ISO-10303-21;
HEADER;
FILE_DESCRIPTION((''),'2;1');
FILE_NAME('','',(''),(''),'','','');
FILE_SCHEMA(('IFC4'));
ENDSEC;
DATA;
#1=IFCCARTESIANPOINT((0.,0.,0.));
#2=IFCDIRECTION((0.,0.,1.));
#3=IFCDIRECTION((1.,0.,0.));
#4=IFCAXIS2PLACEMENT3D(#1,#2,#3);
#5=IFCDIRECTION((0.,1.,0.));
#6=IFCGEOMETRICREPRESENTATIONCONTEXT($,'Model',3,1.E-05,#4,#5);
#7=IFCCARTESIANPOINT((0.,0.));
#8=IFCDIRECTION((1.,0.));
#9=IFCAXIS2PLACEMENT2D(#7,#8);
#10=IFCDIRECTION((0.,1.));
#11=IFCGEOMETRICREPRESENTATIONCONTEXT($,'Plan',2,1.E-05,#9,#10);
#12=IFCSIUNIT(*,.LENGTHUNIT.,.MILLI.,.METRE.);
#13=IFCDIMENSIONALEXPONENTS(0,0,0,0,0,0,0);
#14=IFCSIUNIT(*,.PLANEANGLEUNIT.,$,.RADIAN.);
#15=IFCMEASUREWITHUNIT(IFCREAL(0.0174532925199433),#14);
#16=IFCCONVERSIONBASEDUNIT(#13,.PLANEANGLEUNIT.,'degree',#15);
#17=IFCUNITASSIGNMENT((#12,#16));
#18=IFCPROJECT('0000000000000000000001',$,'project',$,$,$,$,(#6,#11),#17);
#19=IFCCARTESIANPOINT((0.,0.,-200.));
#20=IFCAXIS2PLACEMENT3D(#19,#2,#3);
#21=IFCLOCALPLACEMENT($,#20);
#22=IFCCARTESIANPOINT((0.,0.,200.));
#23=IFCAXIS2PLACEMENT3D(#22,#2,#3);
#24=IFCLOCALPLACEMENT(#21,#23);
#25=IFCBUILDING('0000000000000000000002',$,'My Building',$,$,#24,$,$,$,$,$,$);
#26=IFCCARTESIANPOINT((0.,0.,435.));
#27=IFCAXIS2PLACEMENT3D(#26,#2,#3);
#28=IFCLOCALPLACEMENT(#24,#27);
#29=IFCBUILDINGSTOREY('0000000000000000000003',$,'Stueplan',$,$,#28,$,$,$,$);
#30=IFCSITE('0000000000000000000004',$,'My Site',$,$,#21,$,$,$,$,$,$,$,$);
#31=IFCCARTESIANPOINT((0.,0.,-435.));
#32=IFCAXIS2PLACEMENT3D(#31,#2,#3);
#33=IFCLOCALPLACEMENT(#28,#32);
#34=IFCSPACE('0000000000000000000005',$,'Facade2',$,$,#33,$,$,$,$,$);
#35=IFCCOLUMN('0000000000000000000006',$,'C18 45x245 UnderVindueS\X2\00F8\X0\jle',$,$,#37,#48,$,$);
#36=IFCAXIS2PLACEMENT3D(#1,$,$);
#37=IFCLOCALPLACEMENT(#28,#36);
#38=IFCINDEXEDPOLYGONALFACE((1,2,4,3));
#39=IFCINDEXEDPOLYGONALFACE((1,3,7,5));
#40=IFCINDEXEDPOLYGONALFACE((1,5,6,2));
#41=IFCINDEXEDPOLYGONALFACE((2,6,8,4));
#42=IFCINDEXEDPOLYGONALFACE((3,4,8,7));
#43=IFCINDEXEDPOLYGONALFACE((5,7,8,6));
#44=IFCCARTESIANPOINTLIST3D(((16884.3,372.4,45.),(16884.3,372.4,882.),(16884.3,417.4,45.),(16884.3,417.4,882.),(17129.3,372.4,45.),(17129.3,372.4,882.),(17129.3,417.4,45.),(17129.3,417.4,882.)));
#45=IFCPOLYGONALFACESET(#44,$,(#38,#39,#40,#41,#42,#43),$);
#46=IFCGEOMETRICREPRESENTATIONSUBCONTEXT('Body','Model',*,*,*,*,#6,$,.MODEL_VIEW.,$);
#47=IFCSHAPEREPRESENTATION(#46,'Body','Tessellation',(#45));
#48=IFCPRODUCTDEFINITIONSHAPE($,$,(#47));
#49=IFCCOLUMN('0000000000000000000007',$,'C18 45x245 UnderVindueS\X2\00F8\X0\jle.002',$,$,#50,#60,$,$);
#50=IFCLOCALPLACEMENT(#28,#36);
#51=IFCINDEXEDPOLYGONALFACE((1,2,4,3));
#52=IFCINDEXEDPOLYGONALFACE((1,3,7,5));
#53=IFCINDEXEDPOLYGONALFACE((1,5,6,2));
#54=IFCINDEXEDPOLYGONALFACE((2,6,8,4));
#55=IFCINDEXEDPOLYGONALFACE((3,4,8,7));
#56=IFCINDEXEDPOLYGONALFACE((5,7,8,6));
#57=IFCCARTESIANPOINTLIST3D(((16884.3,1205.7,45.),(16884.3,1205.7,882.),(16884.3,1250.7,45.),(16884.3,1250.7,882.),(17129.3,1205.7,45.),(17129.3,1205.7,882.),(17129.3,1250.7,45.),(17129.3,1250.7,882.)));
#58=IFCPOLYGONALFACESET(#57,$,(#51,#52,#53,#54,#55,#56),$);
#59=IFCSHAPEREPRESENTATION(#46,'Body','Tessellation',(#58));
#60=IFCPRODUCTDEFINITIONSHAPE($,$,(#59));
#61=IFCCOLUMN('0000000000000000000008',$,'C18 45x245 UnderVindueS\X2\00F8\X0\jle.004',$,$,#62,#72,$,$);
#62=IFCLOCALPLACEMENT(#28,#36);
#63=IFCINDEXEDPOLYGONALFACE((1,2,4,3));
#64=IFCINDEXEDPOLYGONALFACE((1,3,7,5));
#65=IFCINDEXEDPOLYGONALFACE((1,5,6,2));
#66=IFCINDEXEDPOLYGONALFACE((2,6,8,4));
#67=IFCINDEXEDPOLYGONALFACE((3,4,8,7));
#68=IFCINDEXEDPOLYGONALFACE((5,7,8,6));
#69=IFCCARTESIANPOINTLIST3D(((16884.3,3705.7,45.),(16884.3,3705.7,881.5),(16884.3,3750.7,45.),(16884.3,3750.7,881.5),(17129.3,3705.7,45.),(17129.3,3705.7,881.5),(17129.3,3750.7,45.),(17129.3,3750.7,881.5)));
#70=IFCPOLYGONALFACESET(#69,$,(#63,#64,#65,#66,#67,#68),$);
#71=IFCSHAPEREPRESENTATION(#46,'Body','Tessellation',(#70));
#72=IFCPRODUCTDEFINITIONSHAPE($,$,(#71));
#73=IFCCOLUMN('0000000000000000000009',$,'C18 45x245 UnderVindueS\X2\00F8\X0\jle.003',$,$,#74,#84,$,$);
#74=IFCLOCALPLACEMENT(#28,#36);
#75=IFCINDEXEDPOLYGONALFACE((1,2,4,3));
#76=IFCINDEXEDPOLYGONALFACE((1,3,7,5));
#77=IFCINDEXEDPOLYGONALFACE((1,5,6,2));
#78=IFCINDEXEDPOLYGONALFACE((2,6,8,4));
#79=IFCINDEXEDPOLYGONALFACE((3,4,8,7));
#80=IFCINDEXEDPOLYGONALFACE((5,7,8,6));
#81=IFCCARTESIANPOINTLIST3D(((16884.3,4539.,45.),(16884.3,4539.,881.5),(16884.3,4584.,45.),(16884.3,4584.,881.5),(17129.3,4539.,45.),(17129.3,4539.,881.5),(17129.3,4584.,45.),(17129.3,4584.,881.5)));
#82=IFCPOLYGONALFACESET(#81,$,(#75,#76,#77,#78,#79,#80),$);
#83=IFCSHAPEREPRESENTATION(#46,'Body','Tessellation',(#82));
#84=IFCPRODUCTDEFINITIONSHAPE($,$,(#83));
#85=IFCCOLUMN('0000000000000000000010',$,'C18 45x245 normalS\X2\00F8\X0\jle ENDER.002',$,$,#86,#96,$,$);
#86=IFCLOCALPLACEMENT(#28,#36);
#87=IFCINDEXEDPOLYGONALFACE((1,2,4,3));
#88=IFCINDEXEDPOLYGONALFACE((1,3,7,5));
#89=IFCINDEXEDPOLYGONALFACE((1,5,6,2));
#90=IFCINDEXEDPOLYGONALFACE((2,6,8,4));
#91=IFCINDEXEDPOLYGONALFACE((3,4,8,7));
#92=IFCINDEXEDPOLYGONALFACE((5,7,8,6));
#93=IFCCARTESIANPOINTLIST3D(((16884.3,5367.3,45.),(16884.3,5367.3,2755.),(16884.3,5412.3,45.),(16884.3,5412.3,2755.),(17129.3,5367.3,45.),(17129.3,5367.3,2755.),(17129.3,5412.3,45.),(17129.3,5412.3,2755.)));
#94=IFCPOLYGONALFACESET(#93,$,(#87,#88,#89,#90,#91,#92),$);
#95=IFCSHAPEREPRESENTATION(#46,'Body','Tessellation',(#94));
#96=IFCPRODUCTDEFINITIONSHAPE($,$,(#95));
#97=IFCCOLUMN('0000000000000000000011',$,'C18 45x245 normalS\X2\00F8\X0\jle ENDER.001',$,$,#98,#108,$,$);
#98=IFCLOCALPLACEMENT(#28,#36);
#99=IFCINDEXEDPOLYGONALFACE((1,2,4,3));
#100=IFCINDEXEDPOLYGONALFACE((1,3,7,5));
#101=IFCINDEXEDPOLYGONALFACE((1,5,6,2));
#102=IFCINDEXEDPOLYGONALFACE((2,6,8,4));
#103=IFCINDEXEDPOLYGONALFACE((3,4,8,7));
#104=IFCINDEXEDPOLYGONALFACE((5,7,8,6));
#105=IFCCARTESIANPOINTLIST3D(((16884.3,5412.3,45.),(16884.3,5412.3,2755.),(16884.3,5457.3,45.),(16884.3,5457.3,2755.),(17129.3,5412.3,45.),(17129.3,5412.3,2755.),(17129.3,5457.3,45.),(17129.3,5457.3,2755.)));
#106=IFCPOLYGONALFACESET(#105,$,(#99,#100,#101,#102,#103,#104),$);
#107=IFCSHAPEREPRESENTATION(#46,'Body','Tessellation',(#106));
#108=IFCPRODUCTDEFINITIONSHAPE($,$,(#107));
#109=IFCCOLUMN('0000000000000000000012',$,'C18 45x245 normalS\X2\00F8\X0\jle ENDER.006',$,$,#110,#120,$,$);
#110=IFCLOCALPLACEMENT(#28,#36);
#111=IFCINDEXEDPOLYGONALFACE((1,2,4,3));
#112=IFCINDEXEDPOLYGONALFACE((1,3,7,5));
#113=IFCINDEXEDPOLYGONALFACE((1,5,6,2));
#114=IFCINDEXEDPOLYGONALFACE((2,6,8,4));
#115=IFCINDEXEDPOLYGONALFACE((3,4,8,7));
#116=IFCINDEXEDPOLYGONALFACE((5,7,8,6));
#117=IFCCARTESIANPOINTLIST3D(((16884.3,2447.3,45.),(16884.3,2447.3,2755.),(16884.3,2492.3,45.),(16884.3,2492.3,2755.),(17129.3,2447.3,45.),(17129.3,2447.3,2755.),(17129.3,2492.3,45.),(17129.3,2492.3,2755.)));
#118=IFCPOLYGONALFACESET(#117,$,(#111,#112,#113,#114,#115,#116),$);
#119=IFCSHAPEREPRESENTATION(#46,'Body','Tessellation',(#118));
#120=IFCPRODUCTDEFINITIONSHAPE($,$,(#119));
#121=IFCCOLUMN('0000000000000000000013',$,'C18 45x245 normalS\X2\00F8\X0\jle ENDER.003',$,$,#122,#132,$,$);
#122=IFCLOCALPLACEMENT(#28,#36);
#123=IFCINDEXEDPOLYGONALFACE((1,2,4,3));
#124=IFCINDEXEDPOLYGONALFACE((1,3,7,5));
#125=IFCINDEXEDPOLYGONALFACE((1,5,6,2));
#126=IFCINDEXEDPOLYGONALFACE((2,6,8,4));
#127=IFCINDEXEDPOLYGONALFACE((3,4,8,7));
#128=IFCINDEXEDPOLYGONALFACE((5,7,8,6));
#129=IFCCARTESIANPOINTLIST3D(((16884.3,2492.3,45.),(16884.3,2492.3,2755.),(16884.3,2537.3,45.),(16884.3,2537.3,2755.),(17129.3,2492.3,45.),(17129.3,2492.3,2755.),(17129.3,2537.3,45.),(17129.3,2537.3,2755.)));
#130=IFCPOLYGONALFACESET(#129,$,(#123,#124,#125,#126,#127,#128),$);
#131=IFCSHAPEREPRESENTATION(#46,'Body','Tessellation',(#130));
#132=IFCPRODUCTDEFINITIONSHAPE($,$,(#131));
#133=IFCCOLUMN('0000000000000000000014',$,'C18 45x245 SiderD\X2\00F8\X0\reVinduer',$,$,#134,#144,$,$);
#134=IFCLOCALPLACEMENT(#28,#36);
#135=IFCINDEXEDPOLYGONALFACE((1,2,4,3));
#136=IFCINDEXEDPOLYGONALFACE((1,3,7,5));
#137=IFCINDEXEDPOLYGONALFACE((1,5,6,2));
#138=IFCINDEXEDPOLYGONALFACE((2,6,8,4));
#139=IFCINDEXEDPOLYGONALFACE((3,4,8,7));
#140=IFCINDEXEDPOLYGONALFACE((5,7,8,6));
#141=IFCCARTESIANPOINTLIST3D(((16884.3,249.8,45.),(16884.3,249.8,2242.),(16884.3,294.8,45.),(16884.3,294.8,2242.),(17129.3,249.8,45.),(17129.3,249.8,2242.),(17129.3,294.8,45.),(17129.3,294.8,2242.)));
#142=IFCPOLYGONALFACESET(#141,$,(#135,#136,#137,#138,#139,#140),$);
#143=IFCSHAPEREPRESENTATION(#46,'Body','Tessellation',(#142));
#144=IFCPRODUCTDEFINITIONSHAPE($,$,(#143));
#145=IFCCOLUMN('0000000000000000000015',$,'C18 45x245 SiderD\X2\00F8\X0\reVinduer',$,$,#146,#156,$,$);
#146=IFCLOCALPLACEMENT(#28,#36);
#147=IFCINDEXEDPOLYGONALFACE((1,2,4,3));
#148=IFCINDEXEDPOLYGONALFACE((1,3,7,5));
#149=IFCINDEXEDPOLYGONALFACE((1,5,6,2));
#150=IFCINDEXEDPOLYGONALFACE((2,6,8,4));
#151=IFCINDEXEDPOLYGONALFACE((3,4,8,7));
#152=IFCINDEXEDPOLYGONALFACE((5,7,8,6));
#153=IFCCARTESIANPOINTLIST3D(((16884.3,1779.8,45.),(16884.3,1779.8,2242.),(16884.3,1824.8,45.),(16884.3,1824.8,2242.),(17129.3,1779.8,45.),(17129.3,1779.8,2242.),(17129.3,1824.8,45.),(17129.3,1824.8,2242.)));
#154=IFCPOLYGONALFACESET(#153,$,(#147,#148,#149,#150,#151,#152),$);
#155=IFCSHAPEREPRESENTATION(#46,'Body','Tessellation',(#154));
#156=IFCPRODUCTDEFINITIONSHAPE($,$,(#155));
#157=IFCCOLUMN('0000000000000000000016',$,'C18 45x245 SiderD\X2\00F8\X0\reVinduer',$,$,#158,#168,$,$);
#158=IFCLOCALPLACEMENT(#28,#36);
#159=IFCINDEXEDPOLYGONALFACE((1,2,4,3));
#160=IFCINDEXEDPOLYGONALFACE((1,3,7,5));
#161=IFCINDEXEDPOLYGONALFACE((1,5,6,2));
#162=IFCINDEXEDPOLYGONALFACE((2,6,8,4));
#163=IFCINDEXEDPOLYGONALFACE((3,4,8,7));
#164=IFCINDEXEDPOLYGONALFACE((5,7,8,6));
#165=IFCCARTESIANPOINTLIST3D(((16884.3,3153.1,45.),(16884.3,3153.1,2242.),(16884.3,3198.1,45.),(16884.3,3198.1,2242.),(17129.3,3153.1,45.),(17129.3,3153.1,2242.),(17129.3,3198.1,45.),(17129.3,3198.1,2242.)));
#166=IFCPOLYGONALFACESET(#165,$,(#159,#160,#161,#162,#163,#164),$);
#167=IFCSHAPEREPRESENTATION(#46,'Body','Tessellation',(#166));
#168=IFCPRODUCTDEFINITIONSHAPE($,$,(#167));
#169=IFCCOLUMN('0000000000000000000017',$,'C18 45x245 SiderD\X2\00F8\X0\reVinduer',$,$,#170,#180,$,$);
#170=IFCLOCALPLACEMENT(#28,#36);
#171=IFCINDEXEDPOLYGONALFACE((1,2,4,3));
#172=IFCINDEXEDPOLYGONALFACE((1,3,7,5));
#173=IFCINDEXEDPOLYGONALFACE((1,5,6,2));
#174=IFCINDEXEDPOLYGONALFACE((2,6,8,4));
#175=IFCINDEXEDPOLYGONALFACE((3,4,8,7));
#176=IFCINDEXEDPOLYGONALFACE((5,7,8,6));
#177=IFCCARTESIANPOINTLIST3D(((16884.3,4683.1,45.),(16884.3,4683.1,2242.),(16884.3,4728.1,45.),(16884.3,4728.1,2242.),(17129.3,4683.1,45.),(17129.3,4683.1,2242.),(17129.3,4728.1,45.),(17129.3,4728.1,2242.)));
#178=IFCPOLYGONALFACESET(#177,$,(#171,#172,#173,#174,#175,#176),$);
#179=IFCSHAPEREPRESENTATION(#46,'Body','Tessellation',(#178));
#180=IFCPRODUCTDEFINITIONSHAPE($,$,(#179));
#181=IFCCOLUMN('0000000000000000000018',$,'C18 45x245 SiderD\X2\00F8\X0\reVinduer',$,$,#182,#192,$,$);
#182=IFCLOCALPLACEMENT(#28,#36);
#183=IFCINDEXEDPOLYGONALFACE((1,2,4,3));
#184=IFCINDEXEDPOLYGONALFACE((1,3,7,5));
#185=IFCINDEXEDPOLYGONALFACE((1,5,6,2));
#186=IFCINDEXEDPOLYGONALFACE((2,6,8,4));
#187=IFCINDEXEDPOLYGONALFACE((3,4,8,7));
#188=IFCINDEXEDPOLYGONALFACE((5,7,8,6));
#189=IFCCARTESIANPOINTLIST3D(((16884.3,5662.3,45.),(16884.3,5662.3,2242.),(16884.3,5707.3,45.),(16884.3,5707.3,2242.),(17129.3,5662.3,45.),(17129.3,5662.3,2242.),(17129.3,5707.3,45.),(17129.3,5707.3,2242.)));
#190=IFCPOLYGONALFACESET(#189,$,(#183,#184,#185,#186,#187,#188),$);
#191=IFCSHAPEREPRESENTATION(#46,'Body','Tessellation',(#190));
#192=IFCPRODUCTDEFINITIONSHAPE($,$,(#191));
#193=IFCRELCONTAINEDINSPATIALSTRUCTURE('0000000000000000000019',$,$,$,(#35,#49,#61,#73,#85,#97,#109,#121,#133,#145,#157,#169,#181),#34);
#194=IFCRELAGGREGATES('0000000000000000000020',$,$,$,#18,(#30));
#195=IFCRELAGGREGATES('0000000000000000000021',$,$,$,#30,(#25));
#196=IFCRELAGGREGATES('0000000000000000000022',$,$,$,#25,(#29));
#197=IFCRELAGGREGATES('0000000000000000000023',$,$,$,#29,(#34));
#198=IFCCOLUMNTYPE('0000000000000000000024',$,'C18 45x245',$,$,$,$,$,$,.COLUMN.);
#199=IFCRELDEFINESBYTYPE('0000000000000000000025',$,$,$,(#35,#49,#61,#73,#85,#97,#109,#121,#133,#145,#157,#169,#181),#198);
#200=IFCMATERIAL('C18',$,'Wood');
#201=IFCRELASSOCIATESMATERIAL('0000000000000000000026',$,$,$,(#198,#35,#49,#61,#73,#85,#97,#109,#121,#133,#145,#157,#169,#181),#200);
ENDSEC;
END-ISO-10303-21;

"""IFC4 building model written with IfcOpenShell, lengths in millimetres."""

from ifc_helpers import new_model, entity, si_unit, converted_unit, direction, frame, origin_with_axes, origin_2d_with_axis, place, context, subcontext, project, spatial, rectangle, extrude, material, material_profile, profile_set, profile_usage, type_object, element, save


model = new_model("IFC4")

# Units and contexts
model_context = context("Model", 3, precision=1e-05, world=origin_with_axes(), true_north=direction((0.0, 1.0, 0.0)))
plan_context = context("Plan", 2, precision=1e-05, world=origin_2d_with_axis(), true_north=direction((0.0, 1.0)))
body_context_1 = subcontext(model_context, "Body", "Model", "MODEL_VIEW")
ifc_project = project(units=[si_unit("LENGTHUNIT", "METRE", prefix="MILLI"), converted_unit("PLANEANGLEUNIT", "degree", entity("IfcReal", 0.0174532925199433), si_unit("PLANEANGLEUNIT", "RADIAN"), dimensions=[0, 0, 0, 0, 0, 0, 0])], contexts=[model_context, plan_context])

# Site, building, storey, space
site_placement = place(None, frame((0.0, 0.0, -200.0), z_axis=(0.0, 0.0, 1.0), x_axis=(1.0, 0.0, 0.0)))
site = spatial("IfcSite", under=ifc_project, at=site_placement, Name="My Site")
building_placement = place(site_placement, frame((0.0, 0.0, 200.0), z_axis=(0.0, 0.0, 1.0), x_axis=(1.0, 0.0, 0.0)))
building = spatial("IfcBuilding", under=site, at=building_placement, Name="My Building")
storey_placement = place(building_placement, frame((0.0, 0.0, 435.0), z_axis=(0.0, 0.0, 1.0), x_axis=(1.0, 0.0, 0.0)))
storey = spatial("IfcBuildingStorey", under=building, at=storey_placement, Name="Stueplan")
space_1_placement = place(storey_placement, frame((0.0, 0.0, -435.0), z_axis=(0.0, 0.0, 1.0), x_axis=(1.0, 0.0, 0.0)))
space_1 = spatial("IfcSpace", under=storey, at=space_1_placement, Name="Facade2")

# Columns
ifc_material = material(Name="C18", Category="Wood")
ifc_material_profile_1 = material_profile(ifc_material, rectangle(XDim=45.0, YDim=245.0))
ifc_profile_set_1 = profile_set([ifc_material_profile_1], Name="woodStructural")
ifc_profile_usage_1 = profile_usage(ifc_profile_set_1, cardinal=9)
column_type = type_object("IfcColumnType", Name="C18 45x245", PredefinedType="COLUMN", material=ifc_profile_set_1)
column_1_placement = place(space_1_placement, frame((17129.3, 417.4, 480.0), z_axis=(0.0, 0.0, 1.0), x_axis=(0.0, -1.0, 0.0)))
element("IfcColumn", 1, at=column_1_placement, inside=space_1, type_object=column_type, material=ifc_profile_usage_1, Name="C18 45x245 UnderVindueSøjle", context=body_context_1, shape_type="SweptSolid", body=[
    extrude(rectangle(XDim=45.0, YDim=245.0), frame((22.5, -122.5, 0.0), z_axis=(0.0, 0.0, 1.0), x_axis=(1.0, 0.0, 0.0)), (0.0, 0.0, 1.0), 837.0),
])
ifc_profile_usage_2 = profile_usage(ifc_profile_set_1, cardinal=9)
column_2_placement = place(space_1_placement, frame((17129.3, 1250.7, 480.0), z_axis=(0.0, 0.0, 1.0), x_axis=(0.0, -1.0, 0.0)))
element("IfcColumn", 2, at=column_2_placement, inside=space_1, type_object=column_type, material=ifc_profile_usage_2, Name="C18 45x245 UnderVindueSøjle.002", context=body_context_1, shape_type="SweptSolid", body=[
    extrude(rectangle(XDim=45.0, YDim=245.0), frame((22.5, -122.5, 0.0), z_axis=(0.0, 0.0, 1.0), x_axis=(1.0, 0.0, 0.0)), (0.0, 0.0, 1.0), 837.0),
])
ifc_profile_usage_3 = profile_usage(ifc_profile_set_1, cardinal=9)
column_3_placement = place(space_1_placement, frame((17129.3, 3750.7, 480.0), z_axis=(0.0, 0.0, 1.0), x_axis=(0.0, -1.0, 0.0)))
element("IfcColumn", 3, at=column_3_placement, inside=space_1, type_object=column_type, material=ifc_profile_usage_3, Name="C18 45x245 UnderVindueSøjle.004", context=body_context_1, shape_type="SweptSolid", body=[
    extrude(rectangle(XDim=45.0, YDim=245.0), frame((22.5, -122.5, 0.0), z_axis=(0.0, 0.0, 1.0), x_axis=(1.0, 0.0, 0.0)), (0.0, 0.0, 1.0), 836.5),
])
ifc_profile_usage_4 = profile_usage(ifc_profile_set_1, cardinal=9)
column_4_placement = place(space_1_placement, frame((17129.3, 4584.0, 480.0), z_axis=(0.0, 0.0, 1.0), x_axis=(0.0, -1.0, 0.0)))
element("IfcColumn", 4, at=column_4_placement, inside=space_1, type_object=column_type, material=ifc_profile_usage_4, Name="C18 45x245 UnderVindueSøjle.003", context=body_context_1, shape_type="SweptSolid", body=[
    extrude(rectangle(XDim=45.0, YDim=245.0), frame((22.5, -122.5, 0.0), z_axis=(0.0, 0.0, 1.0), x_axis=(1.0, 0.0, 0.0)), (0.0, 0.0, 1.0), 836.5),
])
ifc_profile_usage_5 = profile_usage(ifc_profile_set_1, cardinal=9)
column_5_placement = place(space_1_placement, frame((17129.3, 5412.3, 480.0), z_axis=(0.0, 0.0, 1.0), x_axis=(0.0, -1.0, 0.0)))
element("IfcColumn", 5, at=column_5_placement, inside=space_1, type_object=column_type, material=ifc_profile_usage_5, Name="C18 45x245 normalSøjle ENDER.002", context=body_context_1, shape_type="SweptSolid", body=[
    extrude(rectangle(XDim=45.0, YDim=245.0), frame((22.5, -122.5, 0.0), z_axis=(0.0, 0.0, 1.0), x_axis=(1.0, 0.0, 0.0)), (0.0, 0.0, 1.0), 2710.0),
])
ifc_profile_usage_6 = profile_usage(ifc_profile_set_1, cardinal=9)
column_6_placement = place(space_1_placement, frame((17129.3, 5457.3, 480.0), z_axis=(0.0, 0.0, 1.0), x_axis=(0.0, -1.0, 0.0)))
element("IfcColumn", 6, at=column_6_placement, inside=space_1, type_object=column_type, material=ifc_profile_usage_6, Name="C18 45x245 normalSøjle ENDER.001", context=body_context_1, shape_type="SweptSolid", body=[
    extrude(rectangle(XDim=45.0, YDim=245.0), frame((22.5, -122.5, 0.0), z_axis=(0.0, 0.0, 1.0), x_axis=(1.0, 0.0, 0.0)), (0.0, 0.0, 1.0), 2710.0),
])
ifc_profile_usage_7 = profile_usage(ifc_profile_set_1, cardinal=9)
column_7_placement = place(space_1_placement, frame((17129.3, 2492.3, 480.0), z_axis=(0.0, 0.0, 1.0), x_axis=(0.0, -1.0, 0.0)))
element("IfcColumn", 7, at=column_7_placement, inside=space_1, type_object=column_type, material=ifc_profile_usage_7, Name="C18 45x245 normalSøjle ENDER.006", context=body_context_1, shape_type="SweptSolid", body=[
    extrude(rectangle(XDim=45.0, YDim=245.0), frame((22.5, -122.5, 0.0), z_axis=(0.0, 0.0, 1.0), x_axis=(1.0, 0.0, 0.0)), (0.0, 0.0, 1.0), 2710.0),
])
ifc_profile_usage_8 = profile_usage(ifc_profile_set_1, cardinal=9)
column_8_placement = place(space_1_placement, frame((17129.3, 2537.3, 480.0), z_axis=(0.0, 0.0, 1.0), x_axis=(0.0, -1.0, 0.0)))
element("IfcColumn", 8, at=column_8_placement, inside=space_1, type_object=column_type, material=ifc_profile_usage_8, Name="C18 45x245 normalSøjle ENDER.003", context=body_context_1, shape_type="SweptSolid", body=[
    extrude(rectangle(XDim=45.0, YDim=245.0), frame((22.5, -122.5, 0.0), z_axis=(0.0, 0.0, 1.0), x_axis=(1.0, 0.0, 0.0)), (0.0, 0.0, 1.0), 2710.0),
])
ifc_profile_usage_9 = profile_usage(ifc_profile_set_1, cardinal=9)
column_9_placement = place(space_1_placement, frame((17129.3, 294.8, 480.0), z_axis=(0.0, 0.0, 1.0), x_axis=(0.0, -1.0, 0.0)))
element("IfcColumn", 9, at=column_9_placement, inside=space_1, type_object=column_type, material=ifc_profile_usage_9, Name="C18 45x245 SiderDøreVinduer", context=body_context_1, shape_type="SweptSolid", body=[
    extrude(rectangle(XDim=45.0, YDim=245.0), frame((22.5, -122.5, 0.0), z_axis=(0.0, 0.0, 1.0), x_axis=(1.0, 0.0, 0.0)), (0.0, 0.0, 1.0), 2197.0),
])
ifc_profile_usage_10 = profile_usage(ifc_profile_set_1, cardinal=9)
column_10_placement = place(space_1_placement, frame((17129.3, 1824.8, 480.0), z_axis=(0.0, 0.0, 1.0), x_axis=(0.0, -1.0, 0.0)))
element("IfcColumn", 10, at=column_10_placement, inside=space_1, type_object=column_type, material=ifc_profile_usage_10, Name="C18 45x245 SiderDøreVinduer", context=body_context_1, shape_type="SweptSolid", body=[
    extrude(rectangle(XDim=45.0, YDim=245.0), frame((22.5, -122.5, 0.0), z_axis=(0.0, 0.0, 1.0), x_axis=(1.0, 0.0, 0.0)), (0.0, 0.0, 1.0), 2197.0),
])
ifc_profile_usage_11 = profile_usage(ifc_profile_set_1, cardinal=9)
column_11_placement = place(space_1_placement, frame((17129.3, 3198.1, 480.0), z_axis=(0.0, 0.0, 1.0), x_axis=(0.0, -1.0, 0.0)))
element("IfcColumn", 11, at=column_11_placement, inside=space_1, type_object=column_type, material=ifc_profile_usage_11, Name="C18 45x245 SiderDøreVinduer", context=body_context_1, shape_type="SweptSolid", body=[
    extrude(rectangle(XDim=45.0, YDim=245.0), frame((22.5, -122.5, 0.0), z_axis=(0.0, 0.0, 1.0), x_axis=(1.0, 0.0, 0.0)), (0.0, 0.0, 1.0), 2197.0),
])
ifc_profile_usage_12 = profile_usage(ifc_profile_set_1, cardinal=9)
column_12_placement = place(space_1_placement, frame((17129.3, 4728.1, 480.0), z_axis=(0.0, 0.0, 1.0), x_axis=(0.0, -1.0, 0.0)))
element("IfcColumn", 12, at=column_12_placement, inside=space_1, type_object=column_type, material=ifc_profile_usage_12, Name="C18 45x245 SiderDøreVinduer", context=body_context_1, shape_type="SweptSolid", body=[
    extrude(rectangle(XDim=45.0, YDim=245.0), frame((22.5, -122.5, 0.0), z_axis=(0.0, 0.0, 1.0), x_axis=(1.0, 0.0, 0.0)), (0.0, 0.0, 1.0), 2197.0),
])
ifc_profile_usage_13 = profile_usage(ifc_profile_set_1, cardinal=9)
column_13_placement = place(space_1_placement, frame((17129.3, 5707.3, 480.0), z_axis=(0.0, 0.0, 1.0), x_axis=(0.0, -1.0, 0.0)))
element("IfcColumn", 13, at=column_13_placement, inside=space_1, type_object=column_type, material=ifc_profile_usage_13, Name="C18 45x245 SiderDøreVinduer", context=body_context_1, shape_type="SweptSolid", body=[
    extrude(rectangle(XDim=45.0, YDim=245.0), frame((22.5, -122.5, 0.0), z_axis=(0.0, 0.0, 1.0), x_axis=(1.0, 0.0, 0.0)), (0.0, 0.0, 1.0), 2197.0),
])

save(model, "model.ifc")
